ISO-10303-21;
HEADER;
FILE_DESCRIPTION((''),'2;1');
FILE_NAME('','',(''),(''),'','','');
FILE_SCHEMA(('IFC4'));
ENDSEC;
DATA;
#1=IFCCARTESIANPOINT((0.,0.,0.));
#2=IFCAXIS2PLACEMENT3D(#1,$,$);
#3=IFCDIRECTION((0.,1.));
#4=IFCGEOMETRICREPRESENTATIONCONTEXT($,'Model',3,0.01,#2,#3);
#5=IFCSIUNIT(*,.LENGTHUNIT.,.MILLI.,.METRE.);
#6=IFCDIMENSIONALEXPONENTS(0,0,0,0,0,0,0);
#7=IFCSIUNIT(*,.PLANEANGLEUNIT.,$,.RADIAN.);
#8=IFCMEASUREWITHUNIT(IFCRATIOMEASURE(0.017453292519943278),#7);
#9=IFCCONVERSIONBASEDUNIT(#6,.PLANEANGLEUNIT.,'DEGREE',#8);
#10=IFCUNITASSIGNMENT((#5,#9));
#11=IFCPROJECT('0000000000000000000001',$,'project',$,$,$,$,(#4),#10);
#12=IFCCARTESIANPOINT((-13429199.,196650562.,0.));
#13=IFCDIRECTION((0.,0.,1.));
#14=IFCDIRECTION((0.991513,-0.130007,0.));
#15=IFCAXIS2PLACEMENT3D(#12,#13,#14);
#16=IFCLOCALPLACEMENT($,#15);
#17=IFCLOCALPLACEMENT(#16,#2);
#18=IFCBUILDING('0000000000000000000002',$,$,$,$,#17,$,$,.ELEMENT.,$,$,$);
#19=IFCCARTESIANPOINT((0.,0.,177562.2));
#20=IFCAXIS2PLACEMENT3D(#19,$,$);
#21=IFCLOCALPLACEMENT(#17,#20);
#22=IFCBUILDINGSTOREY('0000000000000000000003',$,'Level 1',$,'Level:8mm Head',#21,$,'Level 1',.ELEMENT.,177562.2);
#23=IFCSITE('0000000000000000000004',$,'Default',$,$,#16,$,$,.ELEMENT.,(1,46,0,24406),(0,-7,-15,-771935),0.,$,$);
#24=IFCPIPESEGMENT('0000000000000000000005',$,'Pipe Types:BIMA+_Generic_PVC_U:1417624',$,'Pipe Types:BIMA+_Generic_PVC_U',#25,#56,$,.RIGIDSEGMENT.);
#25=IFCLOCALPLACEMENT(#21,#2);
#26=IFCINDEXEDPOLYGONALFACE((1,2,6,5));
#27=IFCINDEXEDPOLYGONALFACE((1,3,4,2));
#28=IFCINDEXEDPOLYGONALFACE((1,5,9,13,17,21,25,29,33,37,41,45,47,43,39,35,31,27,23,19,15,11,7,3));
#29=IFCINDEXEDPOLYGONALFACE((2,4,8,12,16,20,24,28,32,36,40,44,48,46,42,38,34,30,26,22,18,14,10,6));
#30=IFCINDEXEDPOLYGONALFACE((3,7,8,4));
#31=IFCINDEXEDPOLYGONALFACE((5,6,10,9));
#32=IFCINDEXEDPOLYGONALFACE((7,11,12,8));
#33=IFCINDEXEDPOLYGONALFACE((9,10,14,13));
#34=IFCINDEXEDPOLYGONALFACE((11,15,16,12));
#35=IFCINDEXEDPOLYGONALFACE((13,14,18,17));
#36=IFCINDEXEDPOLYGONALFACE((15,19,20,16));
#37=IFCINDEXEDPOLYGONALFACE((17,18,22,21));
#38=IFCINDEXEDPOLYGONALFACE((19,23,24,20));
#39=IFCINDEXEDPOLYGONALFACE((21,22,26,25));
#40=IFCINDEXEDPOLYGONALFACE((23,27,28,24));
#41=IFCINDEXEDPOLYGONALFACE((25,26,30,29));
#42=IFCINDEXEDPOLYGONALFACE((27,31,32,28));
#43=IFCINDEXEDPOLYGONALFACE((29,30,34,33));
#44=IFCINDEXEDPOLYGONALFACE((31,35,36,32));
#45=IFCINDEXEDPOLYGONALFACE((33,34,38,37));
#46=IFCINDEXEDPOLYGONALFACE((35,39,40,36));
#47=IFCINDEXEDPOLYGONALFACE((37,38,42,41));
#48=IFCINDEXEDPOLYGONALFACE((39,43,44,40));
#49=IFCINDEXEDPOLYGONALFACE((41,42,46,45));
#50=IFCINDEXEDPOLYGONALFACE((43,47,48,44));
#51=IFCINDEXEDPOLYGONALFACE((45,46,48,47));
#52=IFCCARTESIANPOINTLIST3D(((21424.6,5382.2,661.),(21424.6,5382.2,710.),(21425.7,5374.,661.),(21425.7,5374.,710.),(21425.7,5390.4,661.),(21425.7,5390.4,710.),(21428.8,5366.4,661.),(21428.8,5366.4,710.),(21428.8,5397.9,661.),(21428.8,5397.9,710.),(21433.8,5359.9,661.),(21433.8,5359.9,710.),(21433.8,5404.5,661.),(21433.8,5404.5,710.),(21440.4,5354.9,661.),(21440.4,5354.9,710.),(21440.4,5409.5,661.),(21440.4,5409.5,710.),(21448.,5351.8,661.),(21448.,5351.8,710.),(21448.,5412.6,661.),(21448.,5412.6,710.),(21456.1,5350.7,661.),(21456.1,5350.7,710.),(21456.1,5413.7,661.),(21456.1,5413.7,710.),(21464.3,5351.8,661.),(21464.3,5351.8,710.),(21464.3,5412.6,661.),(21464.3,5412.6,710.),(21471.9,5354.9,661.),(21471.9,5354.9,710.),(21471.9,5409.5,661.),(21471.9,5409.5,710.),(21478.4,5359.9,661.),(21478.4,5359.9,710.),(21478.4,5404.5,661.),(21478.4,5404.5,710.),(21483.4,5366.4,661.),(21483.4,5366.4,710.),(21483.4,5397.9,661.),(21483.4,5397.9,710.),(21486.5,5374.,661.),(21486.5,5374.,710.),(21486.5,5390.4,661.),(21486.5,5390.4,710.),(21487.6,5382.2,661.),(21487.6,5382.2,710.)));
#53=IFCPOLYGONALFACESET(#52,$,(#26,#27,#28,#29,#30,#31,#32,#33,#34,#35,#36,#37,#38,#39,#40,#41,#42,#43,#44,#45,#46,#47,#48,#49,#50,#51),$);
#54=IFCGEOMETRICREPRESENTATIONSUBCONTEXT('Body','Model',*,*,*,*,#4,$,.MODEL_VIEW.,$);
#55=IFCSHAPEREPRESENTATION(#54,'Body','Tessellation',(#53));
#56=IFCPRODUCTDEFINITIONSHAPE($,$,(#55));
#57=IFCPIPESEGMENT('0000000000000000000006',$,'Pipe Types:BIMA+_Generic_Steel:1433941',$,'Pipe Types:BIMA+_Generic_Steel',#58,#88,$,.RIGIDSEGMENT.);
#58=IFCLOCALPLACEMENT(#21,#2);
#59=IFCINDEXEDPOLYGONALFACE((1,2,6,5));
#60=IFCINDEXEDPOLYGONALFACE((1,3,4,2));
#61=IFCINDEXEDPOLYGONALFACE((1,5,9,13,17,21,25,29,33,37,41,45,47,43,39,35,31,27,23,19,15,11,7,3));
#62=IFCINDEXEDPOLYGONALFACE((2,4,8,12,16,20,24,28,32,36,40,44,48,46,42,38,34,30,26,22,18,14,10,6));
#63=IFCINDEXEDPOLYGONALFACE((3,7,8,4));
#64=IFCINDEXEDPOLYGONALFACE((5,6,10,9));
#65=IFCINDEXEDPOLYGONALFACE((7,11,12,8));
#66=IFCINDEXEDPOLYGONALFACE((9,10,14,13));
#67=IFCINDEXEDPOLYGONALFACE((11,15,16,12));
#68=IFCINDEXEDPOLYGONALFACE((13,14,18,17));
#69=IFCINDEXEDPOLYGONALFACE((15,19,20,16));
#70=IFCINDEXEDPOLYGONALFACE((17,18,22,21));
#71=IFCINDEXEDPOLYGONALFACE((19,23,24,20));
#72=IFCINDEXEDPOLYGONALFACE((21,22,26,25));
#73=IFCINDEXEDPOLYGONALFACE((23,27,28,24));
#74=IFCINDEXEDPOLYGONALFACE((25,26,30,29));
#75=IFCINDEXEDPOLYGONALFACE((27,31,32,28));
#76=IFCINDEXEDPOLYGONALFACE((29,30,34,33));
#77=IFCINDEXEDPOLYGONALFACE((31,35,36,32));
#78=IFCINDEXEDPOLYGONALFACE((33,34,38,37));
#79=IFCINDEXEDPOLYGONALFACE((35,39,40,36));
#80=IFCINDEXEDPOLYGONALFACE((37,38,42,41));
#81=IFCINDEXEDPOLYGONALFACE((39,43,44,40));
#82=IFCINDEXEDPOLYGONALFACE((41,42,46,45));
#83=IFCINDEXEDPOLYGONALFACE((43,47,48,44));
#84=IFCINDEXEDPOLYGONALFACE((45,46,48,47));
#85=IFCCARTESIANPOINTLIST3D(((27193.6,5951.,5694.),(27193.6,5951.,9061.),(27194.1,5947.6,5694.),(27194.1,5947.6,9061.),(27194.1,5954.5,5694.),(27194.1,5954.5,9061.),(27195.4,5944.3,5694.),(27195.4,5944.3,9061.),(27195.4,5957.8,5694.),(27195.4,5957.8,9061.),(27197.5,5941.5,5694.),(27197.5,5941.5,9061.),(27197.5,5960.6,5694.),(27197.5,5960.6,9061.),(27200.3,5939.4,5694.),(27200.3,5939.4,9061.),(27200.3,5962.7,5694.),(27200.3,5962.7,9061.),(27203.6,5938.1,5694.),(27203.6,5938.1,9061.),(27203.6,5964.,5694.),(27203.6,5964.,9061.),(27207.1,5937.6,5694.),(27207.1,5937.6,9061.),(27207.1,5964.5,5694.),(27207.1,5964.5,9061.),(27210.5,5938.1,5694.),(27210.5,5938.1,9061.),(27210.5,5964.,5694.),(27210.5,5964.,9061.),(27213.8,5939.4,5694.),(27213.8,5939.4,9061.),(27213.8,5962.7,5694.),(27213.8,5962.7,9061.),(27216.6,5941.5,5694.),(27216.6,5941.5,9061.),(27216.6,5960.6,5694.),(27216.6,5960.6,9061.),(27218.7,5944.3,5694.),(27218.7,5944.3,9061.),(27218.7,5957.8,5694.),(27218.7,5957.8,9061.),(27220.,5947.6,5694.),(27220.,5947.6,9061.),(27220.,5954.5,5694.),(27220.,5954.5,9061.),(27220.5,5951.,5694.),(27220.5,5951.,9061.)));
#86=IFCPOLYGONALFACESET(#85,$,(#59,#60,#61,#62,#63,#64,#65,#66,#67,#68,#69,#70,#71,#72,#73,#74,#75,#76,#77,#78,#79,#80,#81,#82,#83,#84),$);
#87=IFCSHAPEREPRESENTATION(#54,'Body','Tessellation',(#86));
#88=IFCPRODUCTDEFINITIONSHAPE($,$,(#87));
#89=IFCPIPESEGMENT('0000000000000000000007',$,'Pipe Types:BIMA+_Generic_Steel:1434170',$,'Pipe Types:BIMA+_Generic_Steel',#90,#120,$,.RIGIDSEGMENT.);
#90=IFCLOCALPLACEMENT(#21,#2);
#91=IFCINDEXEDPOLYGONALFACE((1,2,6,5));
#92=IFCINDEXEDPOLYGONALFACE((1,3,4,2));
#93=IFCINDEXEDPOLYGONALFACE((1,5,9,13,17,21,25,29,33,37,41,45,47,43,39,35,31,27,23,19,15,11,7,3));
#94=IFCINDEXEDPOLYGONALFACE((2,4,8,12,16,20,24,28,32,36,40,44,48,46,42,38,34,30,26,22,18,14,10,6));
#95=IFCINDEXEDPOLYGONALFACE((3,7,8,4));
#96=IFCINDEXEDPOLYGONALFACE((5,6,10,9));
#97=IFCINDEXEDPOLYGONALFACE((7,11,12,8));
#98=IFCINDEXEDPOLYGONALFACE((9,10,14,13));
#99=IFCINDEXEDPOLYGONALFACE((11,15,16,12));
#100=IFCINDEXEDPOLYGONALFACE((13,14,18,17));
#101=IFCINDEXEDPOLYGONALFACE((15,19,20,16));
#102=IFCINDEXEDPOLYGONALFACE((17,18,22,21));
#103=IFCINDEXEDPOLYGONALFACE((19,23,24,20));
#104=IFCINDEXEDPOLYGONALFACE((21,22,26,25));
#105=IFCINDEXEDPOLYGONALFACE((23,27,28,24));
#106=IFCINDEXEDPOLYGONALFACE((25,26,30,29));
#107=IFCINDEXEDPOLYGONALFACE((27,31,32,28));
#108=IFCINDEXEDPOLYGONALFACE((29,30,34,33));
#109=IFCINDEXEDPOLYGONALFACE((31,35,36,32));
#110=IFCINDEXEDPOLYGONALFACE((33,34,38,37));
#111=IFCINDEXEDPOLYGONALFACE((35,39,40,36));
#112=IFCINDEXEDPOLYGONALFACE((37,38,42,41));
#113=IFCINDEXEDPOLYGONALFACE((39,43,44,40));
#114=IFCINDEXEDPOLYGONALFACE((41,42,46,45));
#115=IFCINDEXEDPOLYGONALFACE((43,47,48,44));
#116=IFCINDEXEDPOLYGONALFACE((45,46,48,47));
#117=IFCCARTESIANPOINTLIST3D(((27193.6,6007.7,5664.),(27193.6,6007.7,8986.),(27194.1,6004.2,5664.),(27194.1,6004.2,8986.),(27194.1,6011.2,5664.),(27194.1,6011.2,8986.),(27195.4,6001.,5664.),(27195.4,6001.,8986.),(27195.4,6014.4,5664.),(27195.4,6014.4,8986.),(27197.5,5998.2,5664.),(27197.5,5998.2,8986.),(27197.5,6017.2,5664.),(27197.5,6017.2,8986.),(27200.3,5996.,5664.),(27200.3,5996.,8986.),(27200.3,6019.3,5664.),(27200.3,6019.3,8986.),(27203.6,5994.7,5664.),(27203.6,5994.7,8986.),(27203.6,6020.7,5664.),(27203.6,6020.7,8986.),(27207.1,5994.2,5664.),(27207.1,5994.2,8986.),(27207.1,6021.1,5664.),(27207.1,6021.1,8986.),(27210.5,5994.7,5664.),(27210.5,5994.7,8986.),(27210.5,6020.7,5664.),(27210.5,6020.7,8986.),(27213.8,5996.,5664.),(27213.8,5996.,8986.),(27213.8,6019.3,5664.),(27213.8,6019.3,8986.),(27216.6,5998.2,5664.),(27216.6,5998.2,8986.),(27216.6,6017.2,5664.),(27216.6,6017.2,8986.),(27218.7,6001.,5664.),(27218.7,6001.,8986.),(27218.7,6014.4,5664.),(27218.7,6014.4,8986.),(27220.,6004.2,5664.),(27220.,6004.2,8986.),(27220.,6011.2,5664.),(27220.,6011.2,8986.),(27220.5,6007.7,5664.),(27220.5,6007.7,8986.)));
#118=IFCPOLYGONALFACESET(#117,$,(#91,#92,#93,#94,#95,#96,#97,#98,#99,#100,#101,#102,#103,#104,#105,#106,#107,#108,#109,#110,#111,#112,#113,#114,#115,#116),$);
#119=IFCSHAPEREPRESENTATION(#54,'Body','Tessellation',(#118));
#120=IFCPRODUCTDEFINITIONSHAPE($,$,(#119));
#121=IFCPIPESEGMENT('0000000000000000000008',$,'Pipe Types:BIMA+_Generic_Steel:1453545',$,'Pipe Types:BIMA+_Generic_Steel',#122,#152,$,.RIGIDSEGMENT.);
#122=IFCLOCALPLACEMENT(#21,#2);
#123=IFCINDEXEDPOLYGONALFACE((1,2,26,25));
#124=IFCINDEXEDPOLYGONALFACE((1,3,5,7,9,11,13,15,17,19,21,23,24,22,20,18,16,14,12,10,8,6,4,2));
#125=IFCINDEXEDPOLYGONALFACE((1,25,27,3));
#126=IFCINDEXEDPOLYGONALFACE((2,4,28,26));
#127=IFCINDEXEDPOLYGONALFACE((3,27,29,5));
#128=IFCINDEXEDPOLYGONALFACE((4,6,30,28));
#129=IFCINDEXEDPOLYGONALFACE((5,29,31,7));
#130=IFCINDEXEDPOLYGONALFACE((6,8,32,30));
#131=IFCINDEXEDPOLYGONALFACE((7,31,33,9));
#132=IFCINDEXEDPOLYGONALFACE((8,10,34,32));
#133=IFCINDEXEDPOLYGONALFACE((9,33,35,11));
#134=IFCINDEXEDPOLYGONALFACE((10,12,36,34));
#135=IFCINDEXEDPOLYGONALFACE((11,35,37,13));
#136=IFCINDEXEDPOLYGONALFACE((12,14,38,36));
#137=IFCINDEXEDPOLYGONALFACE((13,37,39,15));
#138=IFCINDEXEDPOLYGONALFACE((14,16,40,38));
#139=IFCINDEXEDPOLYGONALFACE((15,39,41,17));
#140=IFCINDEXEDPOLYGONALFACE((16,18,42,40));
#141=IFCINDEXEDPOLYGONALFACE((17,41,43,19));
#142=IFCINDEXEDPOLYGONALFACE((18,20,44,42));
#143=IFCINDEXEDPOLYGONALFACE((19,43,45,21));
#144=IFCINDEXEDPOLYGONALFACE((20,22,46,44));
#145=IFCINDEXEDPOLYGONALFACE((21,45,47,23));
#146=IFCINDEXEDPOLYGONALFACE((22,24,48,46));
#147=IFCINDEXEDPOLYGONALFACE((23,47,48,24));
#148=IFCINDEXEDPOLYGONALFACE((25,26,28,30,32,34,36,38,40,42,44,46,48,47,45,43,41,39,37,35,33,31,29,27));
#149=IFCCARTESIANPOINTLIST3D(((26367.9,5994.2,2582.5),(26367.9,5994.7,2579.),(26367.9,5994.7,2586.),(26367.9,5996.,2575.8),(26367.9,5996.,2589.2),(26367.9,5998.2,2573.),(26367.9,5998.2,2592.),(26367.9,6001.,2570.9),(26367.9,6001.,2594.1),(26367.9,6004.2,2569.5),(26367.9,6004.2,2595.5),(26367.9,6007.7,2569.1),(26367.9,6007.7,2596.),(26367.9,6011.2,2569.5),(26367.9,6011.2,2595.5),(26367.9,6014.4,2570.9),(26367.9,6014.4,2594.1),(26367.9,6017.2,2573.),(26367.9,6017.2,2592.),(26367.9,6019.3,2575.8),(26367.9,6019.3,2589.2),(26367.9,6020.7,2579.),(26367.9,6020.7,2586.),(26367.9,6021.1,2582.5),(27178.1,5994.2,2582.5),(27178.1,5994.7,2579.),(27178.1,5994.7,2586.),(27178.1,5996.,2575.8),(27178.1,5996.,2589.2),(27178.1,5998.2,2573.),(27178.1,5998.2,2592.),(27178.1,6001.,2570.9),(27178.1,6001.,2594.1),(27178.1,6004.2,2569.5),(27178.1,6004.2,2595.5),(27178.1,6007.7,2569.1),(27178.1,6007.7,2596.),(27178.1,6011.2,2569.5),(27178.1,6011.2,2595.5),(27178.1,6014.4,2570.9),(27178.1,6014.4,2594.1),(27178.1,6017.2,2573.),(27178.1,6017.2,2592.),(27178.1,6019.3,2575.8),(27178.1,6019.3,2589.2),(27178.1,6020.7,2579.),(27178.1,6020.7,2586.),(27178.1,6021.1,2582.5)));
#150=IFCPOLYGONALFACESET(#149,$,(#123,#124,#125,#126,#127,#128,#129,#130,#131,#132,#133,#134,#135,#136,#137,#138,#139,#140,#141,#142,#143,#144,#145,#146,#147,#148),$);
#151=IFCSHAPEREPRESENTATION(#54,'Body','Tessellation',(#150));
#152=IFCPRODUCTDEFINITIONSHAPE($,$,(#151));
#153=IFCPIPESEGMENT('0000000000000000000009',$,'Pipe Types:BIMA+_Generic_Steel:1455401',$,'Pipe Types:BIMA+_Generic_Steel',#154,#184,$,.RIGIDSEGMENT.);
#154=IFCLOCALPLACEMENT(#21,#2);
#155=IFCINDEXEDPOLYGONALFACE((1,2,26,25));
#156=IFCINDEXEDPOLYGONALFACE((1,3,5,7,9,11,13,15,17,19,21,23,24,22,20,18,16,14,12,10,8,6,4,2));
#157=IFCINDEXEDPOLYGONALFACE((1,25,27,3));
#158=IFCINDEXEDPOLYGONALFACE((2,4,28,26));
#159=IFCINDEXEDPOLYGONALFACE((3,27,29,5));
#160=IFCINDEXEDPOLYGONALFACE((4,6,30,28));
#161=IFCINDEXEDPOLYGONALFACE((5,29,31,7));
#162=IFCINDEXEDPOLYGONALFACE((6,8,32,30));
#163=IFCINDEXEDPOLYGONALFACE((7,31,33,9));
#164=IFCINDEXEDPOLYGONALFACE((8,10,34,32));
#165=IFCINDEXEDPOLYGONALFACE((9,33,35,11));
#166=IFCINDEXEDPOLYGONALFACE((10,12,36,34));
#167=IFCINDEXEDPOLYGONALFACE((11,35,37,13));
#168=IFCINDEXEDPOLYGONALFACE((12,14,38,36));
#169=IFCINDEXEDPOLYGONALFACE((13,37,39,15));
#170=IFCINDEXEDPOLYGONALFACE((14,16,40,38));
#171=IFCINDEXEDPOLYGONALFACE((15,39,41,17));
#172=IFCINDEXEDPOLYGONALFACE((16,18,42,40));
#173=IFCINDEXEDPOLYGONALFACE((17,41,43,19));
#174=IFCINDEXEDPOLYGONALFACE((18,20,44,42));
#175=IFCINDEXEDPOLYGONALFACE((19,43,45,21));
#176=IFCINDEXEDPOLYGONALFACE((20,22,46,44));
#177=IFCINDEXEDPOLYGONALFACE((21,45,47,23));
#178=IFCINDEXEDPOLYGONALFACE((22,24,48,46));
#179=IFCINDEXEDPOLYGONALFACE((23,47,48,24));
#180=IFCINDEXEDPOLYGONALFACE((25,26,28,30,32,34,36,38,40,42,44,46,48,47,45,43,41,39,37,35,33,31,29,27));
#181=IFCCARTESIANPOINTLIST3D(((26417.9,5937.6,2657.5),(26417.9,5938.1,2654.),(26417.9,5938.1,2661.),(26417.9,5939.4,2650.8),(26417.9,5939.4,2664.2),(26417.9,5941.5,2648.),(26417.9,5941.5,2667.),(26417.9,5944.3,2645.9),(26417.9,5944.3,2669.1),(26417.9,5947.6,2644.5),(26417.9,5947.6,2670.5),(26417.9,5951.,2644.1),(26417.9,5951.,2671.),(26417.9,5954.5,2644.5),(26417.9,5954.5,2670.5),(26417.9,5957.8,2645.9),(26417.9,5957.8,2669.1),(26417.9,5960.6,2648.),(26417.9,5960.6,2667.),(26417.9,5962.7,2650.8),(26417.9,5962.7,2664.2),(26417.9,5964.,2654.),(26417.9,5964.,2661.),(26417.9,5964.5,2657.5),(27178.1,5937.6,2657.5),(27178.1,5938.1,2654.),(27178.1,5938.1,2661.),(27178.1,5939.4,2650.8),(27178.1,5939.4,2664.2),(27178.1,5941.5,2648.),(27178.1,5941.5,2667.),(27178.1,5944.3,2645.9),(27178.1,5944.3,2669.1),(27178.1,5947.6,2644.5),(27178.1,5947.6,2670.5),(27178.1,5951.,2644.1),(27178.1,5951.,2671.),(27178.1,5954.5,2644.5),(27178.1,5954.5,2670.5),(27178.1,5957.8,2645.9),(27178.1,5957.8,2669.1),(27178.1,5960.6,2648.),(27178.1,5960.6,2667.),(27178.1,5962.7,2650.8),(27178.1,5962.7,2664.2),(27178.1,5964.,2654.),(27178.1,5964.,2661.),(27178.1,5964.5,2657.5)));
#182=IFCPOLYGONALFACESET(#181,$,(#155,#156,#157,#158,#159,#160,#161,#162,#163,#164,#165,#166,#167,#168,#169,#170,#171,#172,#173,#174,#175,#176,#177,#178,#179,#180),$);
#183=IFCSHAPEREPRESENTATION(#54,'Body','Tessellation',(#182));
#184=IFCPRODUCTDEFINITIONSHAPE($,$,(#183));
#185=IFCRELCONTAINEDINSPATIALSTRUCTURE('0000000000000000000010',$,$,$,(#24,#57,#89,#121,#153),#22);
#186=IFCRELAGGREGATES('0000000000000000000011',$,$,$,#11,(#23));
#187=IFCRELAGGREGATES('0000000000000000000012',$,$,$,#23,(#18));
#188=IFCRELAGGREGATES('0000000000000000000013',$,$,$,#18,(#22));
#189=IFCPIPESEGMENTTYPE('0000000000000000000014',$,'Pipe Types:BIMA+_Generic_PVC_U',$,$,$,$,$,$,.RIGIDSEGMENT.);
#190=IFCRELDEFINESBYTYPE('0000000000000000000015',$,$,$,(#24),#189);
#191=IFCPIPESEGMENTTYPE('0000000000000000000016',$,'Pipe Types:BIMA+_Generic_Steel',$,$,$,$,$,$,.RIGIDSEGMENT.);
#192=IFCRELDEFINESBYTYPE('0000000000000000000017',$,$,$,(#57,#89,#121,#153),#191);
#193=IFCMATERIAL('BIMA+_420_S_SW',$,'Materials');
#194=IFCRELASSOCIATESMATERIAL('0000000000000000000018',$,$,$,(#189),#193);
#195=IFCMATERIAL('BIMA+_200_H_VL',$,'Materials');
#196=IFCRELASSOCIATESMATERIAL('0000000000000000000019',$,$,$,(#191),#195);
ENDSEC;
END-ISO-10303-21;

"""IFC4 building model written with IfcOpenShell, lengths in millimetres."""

from ifc_helpers import new_model, entity, si_unit, converted_unit, direction, frame, origin, place, context, subcontext, project, spatial, arc, indexed_curve, outline, extrude, material, type_object, element, save


model = new_model("IFC4")

# Units and contexts
model_context = context("Model", 3, precision=0.01, world=origin(), true_north=direction((0.0, 1.0)))
body_context = subcontext(model_context, "Body", "Model", "MODEL_VIEW")
ifc_project = project(units=[si_unit("LENGTHUNIT", "METRE", prefix="MILLI"), converted_unit("PLANEANGLEUNIT", "DEGREE", entity("IfcRatioMeasure", 0.017453292519943278), si_unit("PLANEANGLEUNIT", "RADIAN"), dimensions=[0, 0, 0, 0, 0, 0, 0])], contexts=[model_context])

# Site, building, storey
site_placement = place(None, frame((-13429199.0, 196650562.0, 0.0), z_axis=(0.0, 0.0, 1.0), x_axis=(0.991513, -0.130007, 0.0)))
site = spatial("IfcSite", under=ifc_project, at=site_placement, Name="Default", CompositionType="ELEMENT", RefLatitude=(1, 46, 0, 24406), RefLongitude=(0, -7, -15, -771935), RefElevation=0.0)
building_placement = place(site_placement, origin())
building = spatial("IfcBuilding", under=site, at=building_placement, CompositionType="ELEMENT")
storey_placement = place(building_placement, frame((0.0, 0.0, 177562.2)))
storey = spatial("IfcBuildingStorey", under=building, at=storey_placement, Name="Level 1", ObjectType="Level:8mm Head", LongName="Level 1", CompositionType="ELEMENT", Elevation=177562.2)

# Pipe segments
ifc_material_1 = material(Name="BIMA+_420_S_SW", Category="Materials")
pipe_segment_type_1 = type_object("IfcPipeSegmentType", Name="Pipe Types:BIMA+_Generic_PVC_U", PredefinedType="RIGIDSEGMENT", material=ifc_material_1)
pipe_segment_1_placement = place(storey_placement, frame((21423.0, 5349.1, 661.0)))
element("IfcPipeSegment", 1, at=pipe_segment_1_placement, inside=storey, type_object=pipe_segment_type_1, Name="Pipe Types:BIMA+_Generic_PVC_U:1417624", ObjectType="Pipe Types:BIMA+_Generic_PVC_U", PredefinedType="RIGIDSEGMENT", context=body_context, shape_type="SweptSolid", body=[
    extrude(outline(indexed_curve([(31.5, 0.0), (22.3, 22.3), (0.0, 31.5), (-22.3, 22.3), (-31.5, 0.0), (-22.3, -22.3), (0.0, -31.5), (22.3, -22.3)], segments=[arc(1, 2, 3), arc(3, 4, 5), arc(5, 6, 7), arc(7, 8, 1)], self_intersect=False)), frame((33.1, 33.1, 0.0), z_axis=(0.0, 0.0, 1.0), x_axis=(-1.0, 0.0, 0.0)), (0.0, 0.0, 1.0), 49.0),
])
ifc_material_2 = material(Name="BIMA+_200_H_VL", Category="Materials")
pipe_segment_type_2 = type_object("IfcPipeSegmentType", Name="Pipe Types:BIMA+_Generic_Steel", PredefinedType="RIGIDSEGMENT", material=ifc_material_2)
pipe_segment_2_placement = place(storey_placement, frame((27192.0, 5936.0, 5694.0)))
element("IfcPipeSegment", 2, at=pipe_segment_2_placement, inside=storey, type_object=pipe_segment_type_2, Name="Pipe Types:BIMA+_Generic_Steel:1433941", ObjectType="Pipe Types:BIMA+_Generic_Steel", PredefinedType="RIGIDSEGMENT", context=body_context, shape_type="SweptSolid", body=[
    extrude(outline(indexed_curve([(13.5, 0.0), (9.5, 9.5), (0.0, 13.5), (-9.5, 9.5), (-13.5, 0.0), (-9.5, -9.5), (0.0, -13.4), (9.5, -9.5)], segments=[arc(1, 2, 3), arc(3, 4, 5), arc(5, 6, 7), arc(7, 8, 1)], self_intersect=False)), frame((15.0, 15.0, 0.0), z_axis=(0.0, 0.0, 1.0), x_axis=(-1.0, 0.0, 0.0)), (0.0, 0.0, 1.0), 3367.0),
])
pipe_segment_3_placement = place(storey_placement, frame((27192.0, 5992.7, 5664.0)))
element("IfcPipeSegment", 3, at=pipe_segment_3_placement, inside=storey, type_object=pipe_segment_type_2, Name="Pipe Types:BIMA+_Generic_Steel:1434170", ObjectType="Pipe Types:BIMA+_Generic_Steel", PredefinedType="RIGIDSEGMENT", context=body_context, shape_type="SweptSolid", body=[
    extrude(outline(indexed_curve([(13.5, 0.0), (9.5, 9.5), (0.0, 13.5), (-9.5, 9.5), (-13.5, 0.0), (-9.5, -9.5), (0.0, -13.4), (9.5, -9.5)], segments=[arc(1, 2, 3), arc(3, 4, 5), arc(5, 6, 7), arc(7, 8, 1)], self_intersect=False)), frame((15.0, 15.0, 0.0)), (0.0, 0.0, 1.0), 3322.0),
])
pipe_segment_4_placement = place(storey_placement, frame((26367.9, 5992.7, 2567.5)))
element("IfcPipeSegment", 4, at=pipe_segment_4_placement, inside=storey, type_object=pipe_segment_type_2, Name="Pipe Types:BIMA+_Generic_Steel:1453545", ObjectType="Pipe Types:BIMA+_Generic_Steel", PredefinedType="RIGIDSEGMENT", context=body_context, shape_type="SweptSolid", body=[
    extrude(outline(indexed_curve([(13.5, 0.0), (9.5, 9.5), (0.0, 13.5), (-9.5, 9.5), (-13.5, 0.0), (-9.5, -9.5), (0.0, -13.5), (9.5, -9.5)], segments=[arc(1, 2, 3), arc(3, 4, 5), arc(5, 6, 7), arc(7, 8, 1)], self_intersect=False)), frame((0.0, 15.0, 15.0), z_axis=(1.0, 0.0, 0.0), x_axis=(0.0, -1.0, 0.0)), (0.0, 0.0, 1.0), 810.2),
])
pipe_segment_5_placement = place(storey_placement, frame((26417.9, 5936.0, 2642.5)))
element("IfcPipeSegment", 5, at=pipe_segment_5_placement, inside=storey, type_object=pipe_segment_type_2, Name="Pipe Types:BIMA+_Generic_Steel:1455401", ObjectType="Pipe Types:BIMA+_Generic_Steel", PredefinedType="RIGIDSEGMENT", context=body_context, shape_type="SweptSolid", body=[
    extrude(outline(indexed_curve([(13.5, 0.0), (9.5, 9.5), (0.0, 13.5), (-9.5, 9.5), (-13.5, 0.0), (-9.5, -9.5), (0.0, -13.5), (9.5, -9.5)], segments=[arc(1, 2, 3), arc(3, 4, 5), arc(5, 6, 7), arc(7, 8, 1)], self_intersect=False)), frame((0.0, 15.0, 15.0), z_axis=(1.0, 0.0, 0.0), x_axis=(0.0, -1.0, 0.0)), (0.0, 0.0, 1.0), 760.2),
])

save(model, "model.ifc")
